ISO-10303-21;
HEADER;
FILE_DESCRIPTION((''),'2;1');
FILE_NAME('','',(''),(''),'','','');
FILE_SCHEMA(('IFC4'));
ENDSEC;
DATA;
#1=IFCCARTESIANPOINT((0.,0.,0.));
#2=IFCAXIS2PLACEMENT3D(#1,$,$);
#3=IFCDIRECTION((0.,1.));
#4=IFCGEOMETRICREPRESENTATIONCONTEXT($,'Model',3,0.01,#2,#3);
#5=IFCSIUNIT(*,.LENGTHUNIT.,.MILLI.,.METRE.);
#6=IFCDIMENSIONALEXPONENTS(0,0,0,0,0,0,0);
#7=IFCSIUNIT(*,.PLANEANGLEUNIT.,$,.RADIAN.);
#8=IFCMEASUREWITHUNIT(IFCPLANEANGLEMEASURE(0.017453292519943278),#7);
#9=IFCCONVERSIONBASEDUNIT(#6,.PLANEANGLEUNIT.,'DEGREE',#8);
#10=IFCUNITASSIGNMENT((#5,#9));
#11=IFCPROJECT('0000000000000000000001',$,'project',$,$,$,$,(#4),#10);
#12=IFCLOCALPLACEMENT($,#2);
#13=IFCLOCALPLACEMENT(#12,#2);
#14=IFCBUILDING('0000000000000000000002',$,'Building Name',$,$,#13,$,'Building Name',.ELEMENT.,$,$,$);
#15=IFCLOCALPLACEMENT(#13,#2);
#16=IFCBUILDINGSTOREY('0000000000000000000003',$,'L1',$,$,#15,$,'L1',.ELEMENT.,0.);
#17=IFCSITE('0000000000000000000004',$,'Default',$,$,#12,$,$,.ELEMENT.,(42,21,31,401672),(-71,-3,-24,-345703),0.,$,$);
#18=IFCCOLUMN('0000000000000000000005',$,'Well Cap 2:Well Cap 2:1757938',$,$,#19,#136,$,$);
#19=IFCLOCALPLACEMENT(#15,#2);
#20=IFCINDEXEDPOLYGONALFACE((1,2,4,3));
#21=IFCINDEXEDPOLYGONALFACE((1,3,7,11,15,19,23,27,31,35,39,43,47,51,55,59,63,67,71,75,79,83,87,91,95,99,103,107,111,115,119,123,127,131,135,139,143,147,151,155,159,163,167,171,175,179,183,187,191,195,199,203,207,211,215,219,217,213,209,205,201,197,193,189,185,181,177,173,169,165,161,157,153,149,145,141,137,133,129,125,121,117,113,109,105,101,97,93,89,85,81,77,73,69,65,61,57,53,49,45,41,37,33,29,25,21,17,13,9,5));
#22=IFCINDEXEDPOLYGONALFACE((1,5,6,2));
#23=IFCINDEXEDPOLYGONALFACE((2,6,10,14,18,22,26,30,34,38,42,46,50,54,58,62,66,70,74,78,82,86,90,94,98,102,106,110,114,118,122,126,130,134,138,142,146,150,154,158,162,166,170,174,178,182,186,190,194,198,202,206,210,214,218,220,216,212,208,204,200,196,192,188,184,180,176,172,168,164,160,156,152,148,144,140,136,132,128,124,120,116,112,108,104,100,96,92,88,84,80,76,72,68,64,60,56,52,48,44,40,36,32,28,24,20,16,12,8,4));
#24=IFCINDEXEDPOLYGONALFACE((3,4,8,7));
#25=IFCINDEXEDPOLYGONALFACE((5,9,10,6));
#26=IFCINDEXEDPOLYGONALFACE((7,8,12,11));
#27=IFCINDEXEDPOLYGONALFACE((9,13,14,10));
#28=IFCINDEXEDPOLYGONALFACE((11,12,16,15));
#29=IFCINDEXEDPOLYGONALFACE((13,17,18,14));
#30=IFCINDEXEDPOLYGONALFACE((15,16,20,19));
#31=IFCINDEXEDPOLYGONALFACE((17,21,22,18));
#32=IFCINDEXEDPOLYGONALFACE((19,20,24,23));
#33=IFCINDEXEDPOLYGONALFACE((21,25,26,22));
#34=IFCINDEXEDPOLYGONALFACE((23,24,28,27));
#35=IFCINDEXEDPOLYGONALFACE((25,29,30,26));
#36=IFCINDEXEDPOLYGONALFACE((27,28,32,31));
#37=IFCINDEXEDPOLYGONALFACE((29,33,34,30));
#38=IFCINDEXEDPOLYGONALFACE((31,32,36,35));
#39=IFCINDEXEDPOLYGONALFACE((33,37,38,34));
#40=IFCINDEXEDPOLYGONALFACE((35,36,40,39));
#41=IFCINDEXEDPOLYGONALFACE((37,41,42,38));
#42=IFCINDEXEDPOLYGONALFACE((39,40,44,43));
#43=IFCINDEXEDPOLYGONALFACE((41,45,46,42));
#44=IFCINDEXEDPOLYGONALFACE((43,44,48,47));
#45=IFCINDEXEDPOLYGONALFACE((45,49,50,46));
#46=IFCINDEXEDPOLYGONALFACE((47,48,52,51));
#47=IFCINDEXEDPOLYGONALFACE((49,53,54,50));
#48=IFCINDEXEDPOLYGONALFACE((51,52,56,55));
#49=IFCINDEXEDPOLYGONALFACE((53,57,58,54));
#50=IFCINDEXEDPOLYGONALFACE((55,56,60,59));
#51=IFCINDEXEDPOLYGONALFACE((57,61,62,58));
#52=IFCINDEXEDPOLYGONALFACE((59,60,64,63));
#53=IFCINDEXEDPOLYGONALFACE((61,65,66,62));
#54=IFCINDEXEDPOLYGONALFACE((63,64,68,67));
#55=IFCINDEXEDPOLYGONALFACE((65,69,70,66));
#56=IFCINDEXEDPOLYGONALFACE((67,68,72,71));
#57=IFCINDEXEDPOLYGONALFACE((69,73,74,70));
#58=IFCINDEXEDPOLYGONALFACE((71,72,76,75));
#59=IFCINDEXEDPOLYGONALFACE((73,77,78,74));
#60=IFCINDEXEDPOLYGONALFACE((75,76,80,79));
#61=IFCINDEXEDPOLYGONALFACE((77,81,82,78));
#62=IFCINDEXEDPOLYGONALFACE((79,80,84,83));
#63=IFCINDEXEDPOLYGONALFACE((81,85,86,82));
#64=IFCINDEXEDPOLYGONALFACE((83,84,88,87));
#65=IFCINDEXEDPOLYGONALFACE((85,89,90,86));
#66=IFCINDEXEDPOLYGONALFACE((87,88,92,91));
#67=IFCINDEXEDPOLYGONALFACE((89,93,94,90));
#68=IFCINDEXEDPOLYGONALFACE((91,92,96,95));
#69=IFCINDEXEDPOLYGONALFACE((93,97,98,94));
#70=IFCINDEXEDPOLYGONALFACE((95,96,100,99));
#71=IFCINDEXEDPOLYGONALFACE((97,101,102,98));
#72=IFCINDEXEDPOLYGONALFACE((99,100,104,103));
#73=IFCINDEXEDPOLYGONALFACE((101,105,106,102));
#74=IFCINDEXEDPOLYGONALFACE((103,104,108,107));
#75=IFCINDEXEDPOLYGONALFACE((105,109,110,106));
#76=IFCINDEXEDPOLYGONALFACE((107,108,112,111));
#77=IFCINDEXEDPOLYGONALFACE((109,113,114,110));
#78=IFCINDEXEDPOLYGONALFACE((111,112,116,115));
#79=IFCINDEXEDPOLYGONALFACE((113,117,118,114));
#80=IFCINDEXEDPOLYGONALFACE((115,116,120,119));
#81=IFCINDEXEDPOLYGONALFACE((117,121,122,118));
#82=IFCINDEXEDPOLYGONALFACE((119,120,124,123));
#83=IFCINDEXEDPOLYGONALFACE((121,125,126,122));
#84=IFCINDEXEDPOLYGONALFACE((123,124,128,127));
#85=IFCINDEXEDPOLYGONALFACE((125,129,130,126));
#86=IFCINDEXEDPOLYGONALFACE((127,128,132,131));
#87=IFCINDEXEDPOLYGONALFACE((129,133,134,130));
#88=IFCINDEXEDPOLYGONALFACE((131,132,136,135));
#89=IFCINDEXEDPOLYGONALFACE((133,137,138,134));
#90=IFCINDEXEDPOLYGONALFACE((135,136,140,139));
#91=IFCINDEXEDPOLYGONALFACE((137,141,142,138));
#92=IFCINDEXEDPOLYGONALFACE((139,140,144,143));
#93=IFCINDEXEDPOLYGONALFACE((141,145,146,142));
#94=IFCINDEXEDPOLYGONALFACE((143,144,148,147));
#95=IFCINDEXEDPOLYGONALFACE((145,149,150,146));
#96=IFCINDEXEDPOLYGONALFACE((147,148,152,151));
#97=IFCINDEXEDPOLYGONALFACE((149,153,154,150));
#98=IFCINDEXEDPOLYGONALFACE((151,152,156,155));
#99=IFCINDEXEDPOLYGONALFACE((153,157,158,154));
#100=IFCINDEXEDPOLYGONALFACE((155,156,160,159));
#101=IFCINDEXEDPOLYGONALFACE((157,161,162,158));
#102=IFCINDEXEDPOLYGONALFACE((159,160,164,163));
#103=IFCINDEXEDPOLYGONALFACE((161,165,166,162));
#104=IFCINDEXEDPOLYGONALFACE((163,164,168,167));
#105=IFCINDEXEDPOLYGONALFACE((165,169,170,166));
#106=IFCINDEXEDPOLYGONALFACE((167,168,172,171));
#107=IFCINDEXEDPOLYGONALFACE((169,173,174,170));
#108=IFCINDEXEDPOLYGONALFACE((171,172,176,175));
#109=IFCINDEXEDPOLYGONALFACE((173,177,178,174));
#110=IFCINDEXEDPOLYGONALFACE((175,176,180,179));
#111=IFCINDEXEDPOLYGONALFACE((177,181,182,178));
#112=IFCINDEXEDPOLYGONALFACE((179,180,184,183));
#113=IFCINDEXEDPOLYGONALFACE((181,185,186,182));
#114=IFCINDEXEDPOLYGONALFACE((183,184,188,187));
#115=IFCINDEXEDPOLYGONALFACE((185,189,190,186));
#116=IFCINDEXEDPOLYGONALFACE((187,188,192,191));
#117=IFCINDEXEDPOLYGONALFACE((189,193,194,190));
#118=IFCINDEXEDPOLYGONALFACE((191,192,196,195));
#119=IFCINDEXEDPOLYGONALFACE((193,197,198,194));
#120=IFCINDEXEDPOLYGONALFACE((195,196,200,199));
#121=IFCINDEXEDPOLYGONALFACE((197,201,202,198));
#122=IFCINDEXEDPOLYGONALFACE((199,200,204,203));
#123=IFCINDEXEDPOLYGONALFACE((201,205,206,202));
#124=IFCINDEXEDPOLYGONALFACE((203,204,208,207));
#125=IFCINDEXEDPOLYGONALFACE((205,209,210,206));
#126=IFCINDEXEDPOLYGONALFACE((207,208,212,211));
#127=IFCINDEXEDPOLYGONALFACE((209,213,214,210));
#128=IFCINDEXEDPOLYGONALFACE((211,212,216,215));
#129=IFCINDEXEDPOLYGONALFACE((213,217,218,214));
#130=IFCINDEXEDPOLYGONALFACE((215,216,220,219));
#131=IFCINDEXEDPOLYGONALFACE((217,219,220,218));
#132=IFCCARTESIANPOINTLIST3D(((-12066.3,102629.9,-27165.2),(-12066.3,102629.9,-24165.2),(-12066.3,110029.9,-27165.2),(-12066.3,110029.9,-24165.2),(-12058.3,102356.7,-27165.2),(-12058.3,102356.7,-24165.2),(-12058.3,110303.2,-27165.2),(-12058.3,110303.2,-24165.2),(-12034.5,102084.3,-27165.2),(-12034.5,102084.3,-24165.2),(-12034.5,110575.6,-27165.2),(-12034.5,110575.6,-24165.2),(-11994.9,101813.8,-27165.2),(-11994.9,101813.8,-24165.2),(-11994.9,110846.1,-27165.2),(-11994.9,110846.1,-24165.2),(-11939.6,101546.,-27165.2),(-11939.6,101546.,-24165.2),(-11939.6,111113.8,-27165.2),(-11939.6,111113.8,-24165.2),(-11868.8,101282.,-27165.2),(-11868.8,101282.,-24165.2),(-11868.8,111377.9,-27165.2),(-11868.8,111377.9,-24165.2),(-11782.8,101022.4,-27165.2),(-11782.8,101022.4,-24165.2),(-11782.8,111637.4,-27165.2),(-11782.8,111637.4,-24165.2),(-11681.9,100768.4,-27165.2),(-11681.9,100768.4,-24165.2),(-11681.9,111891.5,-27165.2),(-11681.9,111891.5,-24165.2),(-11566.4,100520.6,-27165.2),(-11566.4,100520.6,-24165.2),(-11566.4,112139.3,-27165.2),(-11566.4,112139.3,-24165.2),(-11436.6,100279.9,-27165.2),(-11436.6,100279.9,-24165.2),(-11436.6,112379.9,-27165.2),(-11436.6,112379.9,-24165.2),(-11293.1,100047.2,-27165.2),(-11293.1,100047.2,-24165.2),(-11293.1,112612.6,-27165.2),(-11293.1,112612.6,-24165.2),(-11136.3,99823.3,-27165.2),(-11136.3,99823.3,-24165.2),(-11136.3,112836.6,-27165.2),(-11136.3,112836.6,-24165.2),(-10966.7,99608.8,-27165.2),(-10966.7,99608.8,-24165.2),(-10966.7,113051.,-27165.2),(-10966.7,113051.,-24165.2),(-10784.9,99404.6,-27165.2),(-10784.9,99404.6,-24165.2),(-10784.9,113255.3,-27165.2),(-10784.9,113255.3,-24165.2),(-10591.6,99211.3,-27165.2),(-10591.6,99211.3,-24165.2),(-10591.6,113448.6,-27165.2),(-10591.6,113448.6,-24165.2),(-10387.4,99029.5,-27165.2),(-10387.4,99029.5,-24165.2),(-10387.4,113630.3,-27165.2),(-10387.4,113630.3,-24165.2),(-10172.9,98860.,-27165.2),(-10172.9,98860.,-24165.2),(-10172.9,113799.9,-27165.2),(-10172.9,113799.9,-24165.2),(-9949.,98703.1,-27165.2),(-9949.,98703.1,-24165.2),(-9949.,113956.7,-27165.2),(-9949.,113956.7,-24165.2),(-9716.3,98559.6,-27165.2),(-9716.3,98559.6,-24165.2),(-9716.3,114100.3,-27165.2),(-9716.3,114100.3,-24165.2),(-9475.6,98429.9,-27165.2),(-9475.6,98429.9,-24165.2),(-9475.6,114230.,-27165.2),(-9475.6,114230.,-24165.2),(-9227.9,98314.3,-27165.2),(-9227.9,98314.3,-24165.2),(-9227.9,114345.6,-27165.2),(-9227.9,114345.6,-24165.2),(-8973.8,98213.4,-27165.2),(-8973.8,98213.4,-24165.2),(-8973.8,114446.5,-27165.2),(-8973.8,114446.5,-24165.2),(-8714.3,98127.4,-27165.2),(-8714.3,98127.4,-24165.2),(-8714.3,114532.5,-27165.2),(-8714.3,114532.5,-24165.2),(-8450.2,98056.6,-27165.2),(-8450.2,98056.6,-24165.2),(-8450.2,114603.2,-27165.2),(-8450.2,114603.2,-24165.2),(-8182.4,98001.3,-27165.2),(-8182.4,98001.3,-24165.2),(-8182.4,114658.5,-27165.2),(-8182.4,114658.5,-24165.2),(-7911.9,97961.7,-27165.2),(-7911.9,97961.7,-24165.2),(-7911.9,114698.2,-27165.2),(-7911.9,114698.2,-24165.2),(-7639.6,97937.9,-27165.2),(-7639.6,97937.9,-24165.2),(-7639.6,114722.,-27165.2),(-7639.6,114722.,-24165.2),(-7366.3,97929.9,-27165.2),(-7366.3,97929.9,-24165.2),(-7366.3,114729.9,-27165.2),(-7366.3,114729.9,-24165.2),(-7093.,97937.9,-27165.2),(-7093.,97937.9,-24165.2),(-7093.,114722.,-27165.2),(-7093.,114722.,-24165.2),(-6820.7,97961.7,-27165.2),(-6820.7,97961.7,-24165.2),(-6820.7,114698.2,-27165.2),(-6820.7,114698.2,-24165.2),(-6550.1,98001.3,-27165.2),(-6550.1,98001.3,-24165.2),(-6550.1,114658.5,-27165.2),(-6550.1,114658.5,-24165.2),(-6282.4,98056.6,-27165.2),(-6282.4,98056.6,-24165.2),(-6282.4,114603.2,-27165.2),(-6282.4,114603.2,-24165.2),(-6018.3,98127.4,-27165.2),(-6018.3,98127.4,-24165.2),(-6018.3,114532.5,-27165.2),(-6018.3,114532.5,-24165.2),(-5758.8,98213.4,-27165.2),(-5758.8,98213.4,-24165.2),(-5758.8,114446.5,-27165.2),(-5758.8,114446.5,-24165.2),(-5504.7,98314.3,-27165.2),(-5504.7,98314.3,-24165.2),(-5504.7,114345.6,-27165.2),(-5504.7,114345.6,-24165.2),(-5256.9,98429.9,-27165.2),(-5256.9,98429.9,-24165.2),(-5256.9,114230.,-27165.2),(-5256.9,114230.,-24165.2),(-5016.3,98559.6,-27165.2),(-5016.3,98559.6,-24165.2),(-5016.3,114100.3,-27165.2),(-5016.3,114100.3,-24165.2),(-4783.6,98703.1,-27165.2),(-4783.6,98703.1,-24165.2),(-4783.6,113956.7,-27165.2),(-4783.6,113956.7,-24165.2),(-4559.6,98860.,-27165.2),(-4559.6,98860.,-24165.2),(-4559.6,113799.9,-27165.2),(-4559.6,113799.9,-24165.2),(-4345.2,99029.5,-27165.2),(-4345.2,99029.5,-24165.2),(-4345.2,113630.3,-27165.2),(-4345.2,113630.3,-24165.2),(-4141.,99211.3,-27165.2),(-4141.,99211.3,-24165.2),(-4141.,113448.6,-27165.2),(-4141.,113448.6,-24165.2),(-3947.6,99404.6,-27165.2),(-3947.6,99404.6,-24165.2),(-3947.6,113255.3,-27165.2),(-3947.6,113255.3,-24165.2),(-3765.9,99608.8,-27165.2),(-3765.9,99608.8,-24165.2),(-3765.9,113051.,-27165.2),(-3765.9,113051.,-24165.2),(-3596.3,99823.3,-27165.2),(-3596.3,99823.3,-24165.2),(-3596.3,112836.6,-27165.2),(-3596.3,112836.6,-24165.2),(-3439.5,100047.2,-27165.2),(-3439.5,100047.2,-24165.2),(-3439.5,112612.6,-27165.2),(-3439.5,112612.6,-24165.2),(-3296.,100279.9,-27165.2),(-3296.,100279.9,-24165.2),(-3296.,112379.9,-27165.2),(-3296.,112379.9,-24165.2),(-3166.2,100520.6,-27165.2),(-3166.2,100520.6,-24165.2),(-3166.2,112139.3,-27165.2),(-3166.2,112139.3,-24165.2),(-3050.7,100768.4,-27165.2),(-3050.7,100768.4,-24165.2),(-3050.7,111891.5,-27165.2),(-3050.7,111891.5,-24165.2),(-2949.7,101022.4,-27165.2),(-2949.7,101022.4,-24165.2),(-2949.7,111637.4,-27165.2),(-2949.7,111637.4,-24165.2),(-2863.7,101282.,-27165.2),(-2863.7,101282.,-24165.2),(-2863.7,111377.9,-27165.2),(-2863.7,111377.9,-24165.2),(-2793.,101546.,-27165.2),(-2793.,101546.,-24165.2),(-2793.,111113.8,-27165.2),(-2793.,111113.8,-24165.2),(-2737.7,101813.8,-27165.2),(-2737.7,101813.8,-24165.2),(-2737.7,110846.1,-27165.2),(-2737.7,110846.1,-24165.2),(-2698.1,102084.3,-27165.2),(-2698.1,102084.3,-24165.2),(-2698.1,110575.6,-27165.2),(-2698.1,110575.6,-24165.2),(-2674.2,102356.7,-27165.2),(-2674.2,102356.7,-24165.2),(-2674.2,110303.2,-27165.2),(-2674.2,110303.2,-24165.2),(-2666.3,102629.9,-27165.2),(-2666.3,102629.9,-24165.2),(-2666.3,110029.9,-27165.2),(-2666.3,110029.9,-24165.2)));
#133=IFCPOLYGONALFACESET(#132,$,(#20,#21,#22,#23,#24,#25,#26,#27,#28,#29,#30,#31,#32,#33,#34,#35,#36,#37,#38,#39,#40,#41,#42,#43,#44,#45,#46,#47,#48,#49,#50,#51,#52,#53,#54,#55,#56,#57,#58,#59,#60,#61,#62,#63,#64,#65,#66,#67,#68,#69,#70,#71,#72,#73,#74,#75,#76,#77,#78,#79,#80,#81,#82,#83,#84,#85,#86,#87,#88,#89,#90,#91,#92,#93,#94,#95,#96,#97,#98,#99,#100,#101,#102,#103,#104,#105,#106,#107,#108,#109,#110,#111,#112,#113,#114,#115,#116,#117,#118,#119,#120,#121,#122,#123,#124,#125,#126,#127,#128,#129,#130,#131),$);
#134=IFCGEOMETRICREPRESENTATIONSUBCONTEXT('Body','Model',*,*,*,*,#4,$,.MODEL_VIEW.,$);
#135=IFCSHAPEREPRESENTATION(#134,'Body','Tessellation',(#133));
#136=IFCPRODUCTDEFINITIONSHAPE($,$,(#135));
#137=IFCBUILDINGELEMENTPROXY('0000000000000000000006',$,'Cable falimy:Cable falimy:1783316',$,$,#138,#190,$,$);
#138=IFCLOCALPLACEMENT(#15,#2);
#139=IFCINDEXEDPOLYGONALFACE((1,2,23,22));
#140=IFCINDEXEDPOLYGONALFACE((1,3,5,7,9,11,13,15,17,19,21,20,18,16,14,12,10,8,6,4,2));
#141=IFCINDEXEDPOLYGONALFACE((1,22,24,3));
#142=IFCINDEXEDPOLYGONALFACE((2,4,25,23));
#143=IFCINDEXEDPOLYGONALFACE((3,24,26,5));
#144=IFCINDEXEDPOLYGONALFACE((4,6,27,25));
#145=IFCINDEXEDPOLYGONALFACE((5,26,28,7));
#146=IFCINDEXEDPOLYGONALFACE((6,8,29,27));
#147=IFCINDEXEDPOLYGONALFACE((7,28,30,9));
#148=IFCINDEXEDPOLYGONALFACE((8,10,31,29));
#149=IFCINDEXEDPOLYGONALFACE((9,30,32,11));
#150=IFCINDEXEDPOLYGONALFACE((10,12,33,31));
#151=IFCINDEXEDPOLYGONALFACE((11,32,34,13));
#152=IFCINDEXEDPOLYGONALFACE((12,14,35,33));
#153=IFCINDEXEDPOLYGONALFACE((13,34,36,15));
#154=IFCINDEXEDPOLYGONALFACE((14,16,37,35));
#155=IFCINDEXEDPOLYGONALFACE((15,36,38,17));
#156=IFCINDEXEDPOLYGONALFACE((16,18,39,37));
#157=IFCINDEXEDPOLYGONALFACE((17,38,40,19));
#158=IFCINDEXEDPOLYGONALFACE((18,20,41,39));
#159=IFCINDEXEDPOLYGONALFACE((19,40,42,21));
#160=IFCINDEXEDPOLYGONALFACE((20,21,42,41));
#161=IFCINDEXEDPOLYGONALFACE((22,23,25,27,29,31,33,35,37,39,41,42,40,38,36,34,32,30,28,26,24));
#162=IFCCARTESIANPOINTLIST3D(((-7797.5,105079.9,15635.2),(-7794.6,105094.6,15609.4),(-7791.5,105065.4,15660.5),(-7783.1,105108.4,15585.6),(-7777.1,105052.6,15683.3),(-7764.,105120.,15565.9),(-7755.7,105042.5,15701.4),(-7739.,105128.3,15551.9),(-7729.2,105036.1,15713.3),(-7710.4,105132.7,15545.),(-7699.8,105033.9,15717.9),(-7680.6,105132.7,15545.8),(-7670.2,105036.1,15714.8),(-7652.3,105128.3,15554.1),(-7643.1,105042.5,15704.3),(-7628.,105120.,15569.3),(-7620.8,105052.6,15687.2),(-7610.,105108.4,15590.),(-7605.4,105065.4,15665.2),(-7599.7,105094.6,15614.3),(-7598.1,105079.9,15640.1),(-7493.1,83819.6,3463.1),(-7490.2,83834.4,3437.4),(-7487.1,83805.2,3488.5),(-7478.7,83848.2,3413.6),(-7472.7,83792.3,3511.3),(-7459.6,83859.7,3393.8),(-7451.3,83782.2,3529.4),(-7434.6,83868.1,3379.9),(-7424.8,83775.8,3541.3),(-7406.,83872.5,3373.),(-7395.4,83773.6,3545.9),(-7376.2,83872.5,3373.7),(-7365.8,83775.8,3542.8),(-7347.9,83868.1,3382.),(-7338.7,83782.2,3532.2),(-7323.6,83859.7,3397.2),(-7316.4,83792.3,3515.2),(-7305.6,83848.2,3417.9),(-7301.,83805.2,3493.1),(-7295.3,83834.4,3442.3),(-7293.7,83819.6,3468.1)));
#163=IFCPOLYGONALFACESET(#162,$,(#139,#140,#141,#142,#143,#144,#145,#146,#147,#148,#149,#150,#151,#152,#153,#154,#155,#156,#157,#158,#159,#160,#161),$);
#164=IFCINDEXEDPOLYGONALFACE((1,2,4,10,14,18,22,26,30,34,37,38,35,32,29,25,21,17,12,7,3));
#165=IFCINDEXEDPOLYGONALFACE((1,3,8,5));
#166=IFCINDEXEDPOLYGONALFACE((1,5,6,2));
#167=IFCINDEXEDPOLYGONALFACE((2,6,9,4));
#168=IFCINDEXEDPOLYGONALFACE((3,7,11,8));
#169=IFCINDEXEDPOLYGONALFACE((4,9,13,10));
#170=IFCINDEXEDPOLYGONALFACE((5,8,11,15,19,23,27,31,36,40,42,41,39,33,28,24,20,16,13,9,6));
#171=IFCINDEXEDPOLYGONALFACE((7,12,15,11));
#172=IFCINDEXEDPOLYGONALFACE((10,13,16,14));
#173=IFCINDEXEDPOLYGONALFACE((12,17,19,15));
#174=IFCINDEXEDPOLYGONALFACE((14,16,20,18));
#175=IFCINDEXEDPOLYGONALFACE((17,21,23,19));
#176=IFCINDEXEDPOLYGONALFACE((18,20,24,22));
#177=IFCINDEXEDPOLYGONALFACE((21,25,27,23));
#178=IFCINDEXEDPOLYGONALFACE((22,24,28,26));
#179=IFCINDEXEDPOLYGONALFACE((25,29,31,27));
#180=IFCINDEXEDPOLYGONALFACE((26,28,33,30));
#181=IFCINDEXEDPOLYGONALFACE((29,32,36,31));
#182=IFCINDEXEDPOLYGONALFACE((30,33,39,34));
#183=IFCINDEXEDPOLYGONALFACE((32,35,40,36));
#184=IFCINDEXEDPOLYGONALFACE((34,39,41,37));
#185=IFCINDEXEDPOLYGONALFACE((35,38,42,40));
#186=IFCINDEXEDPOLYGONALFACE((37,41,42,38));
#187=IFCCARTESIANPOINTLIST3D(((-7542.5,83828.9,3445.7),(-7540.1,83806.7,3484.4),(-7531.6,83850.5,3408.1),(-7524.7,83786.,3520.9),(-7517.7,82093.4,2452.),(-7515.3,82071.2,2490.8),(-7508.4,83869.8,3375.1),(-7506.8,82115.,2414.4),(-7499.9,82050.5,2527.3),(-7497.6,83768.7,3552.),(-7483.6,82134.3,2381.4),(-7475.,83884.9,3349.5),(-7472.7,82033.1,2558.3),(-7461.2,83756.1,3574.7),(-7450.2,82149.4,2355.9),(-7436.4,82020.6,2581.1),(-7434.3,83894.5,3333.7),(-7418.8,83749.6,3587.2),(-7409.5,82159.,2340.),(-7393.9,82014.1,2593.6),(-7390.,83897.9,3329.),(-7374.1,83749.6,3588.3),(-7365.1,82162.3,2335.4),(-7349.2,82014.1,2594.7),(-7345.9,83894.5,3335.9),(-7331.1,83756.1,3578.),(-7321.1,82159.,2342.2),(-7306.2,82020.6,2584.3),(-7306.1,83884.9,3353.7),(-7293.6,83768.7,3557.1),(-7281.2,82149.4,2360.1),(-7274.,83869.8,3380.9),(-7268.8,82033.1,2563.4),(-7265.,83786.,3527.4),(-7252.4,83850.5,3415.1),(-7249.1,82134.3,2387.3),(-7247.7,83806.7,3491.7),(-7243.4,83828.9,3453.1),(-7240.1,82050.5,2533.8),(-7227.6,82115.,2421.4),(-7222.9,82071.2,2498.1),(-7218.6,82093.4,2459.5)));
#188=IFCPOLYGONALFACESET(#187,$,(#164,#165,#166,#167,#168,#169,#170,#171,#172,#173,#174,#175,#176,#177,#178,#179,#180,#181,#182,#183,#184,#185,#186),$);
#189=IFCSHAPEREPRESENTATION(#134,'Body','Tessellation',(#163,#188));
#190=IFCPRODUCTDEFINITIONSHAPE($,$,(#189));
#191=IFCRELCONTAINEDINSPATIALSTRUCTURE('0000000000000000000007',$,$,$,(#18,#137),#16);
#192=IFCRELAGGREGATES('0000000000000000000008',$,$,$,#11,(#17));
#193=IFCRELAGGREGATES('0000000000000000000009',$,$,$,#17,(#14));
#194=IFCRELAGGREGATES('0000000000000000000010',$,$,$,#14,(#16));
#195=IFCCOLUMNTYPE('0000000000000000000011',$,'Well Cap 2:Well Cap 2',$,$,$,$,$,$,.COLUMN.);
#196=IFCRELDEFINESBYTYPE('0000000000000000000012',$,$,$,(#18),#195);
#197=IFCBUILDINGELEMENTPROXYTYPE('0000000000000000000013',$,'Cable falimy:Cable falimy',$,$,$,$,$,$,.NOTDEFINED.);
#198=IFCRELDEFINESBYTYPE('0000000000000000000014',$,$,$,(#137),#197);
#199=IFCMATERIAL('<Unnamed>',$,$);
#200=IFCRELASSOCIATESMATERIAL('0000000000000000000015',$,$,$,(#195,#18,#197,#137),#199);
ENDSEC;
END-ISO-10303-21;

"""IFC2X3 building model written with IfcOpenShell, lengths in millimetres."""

from ifc_helpers import new_model, entity, si_unit, converted_unit, direction, frame, frame_2d, origin, place, context, subcontext, project, spatial, polyline, circle_curve, parameter, trimmed, segment, composite_curve, circle, outline, extrude, source, transform, mapped, material, type_object, type_shapes, element, save


model = new_model("IFC2X3")

# Units and contexts
model_context = context("Model", 3, precision=0.01, world=origin(), true_north=direction((0.0, 1.0)))
body_context = subcontext(model_context, "Body", "Model", "MODEL_VIEW")
ifc_project = project(units=[si_unit("LENGTHUNIT", "METRE", prefix="MILLI"), converted_unit("PLANEANGLEUNIT", "DEGREE", entity("IfcPlaneAngleMeasure", 0.017453292519943278), si_unit("PLANEANGLEUNIT", "RADIAN"), dimensions=[0, 0, 0, 0, 0, 0, 0])], contexts=[model_context])

# Site, building, storey
site_placement = place(None, origin())
site = spatial("IfcSite", under=ifc_project, at=site_placement, Name="Default", CompositionType="ELEMENT", RefLatitude=(42, 21, 31, 401672), RefLongitude=(-71, -3, -24, -345703), RefElevation=0.0)
building_placement = place(site_placement, origin())
building = spatial("IfcBuilding", under=site, at=building_placement, Name="Building Name", LongName="Building Name", CompositionType="ELEMENT")
storey_placement = place(building_placement, origin())
storey = spatial("IfcBuildingStorey", under=building, at=storey_placement, Name="L1", LongName="L1", CompositionType="ELEMENT", Elevation=0.0)

# Column
ifc_material = material(Name="<Unnamed>")
column_type_1 = type_object("IfcColumnType", Name="Well Cap 2:Well Cap 2", PredefinedType="COLUMN", material=ifc_material)
shared_shape_1 = source(origin(), body_context, "Body", "SweptSolid", [
    extrude(outline(composite_curve([segment(polyline([(-3700.0, -4700.0), (3700.0, -4700.0)]), True, "CONTINUOUS"), segment(trimmed(circle_curve(frame_2d((3700.0, 0.0), x_axis=(0.0, -1.0)), 4700.0), [parameter(0.0)], [parameter(180.0)], True, "PARAMETER"), True, "CONTINUOUS"), segment(polyline([(3700.0, 4700.0), (-3700.0, 4700.0)]), True, "CONTINUOUS"), segment(trimmed(circle_curve(frame_2d((-3700.0, 0.0), x_axis=(0.0, 1.0)), 4700.0), [parameter(0.0)], [parameter(180.0)], True, "PARAMETER"), True, "CONTINUOUS")], self_intersect=False)), frame((8064.3, 0.0, 0.0), z_axis=(0.0, 0.0, 1.0), x_axis=(0.0, -1.0, 0.0)), (0.0, 0.0, 1.0), 3000.0),
])
type_shapes(column_type_1, [shared_shape_1])
column_1_placement = place(storey_placement, frame((-15430.5, 106329.9, -27165.2)))
element("IfcColumn", 1, at=column_1_placement, inside=storey, type_object=column_type_1, material=ifc_material, Name="Well Cap 2:Well Cap 2:1757938", context=body_context, shape_type="MappedRepresentation", body=[
    mapped(shared_shape_1, transform((0.0, 0.0, 0.0), scale=1.0)),
])

# Building element proxy
building_element_proxy_type_1 = type_object("IfcBuildingElementProxyType", Name="Cable falimy:Cable falimy", PredefinedType="NOTDEFINED", material=ifc_material)
shared_shape_2 = source(origin(), body_context, "Body", "SweptSolid", [
    extrude(circle(Radius=100.0, at=frame_2d((0.0, 0.0), x_axis=(1.0, 0.0))), frame((0.0, 0.0, 0.0), z_axis=(0.867765, 0.0, 0.496974), x_axis=(-0.496974, 0.0, 0.867765)), (0.0, 0.0, 1.0), 24500.0),
    extrude(circle(Radius=150.0, at=frame_2d((0.0, 0.0), x_axis=(1.0, 0.0))), frame((-1735.5, 0.0, -993.9), z_axis=(0.867765, 0.0, 0.496974), x_axis=(0.496974, 0.0, -0.867765)), (0.0, 0.0, 1.0), 2000.0),
])
type_shapes(building_element_proxy_type_1, [shared_shape_2])
proxy_1_placement = place(storey_placement, frame((-7393.2, 83823.3, 3459.1), z_axis=(-0.025001, 0.0, 0.999687), x_axis=(0.0, 1.0, 0.0)))
element("IfcBuildingElementProxy", 2, at=proxy_1_placement, inside=storey, type_object=building_element_proxy_type_1, material=ifc_material, Name="Cable falimy:Cable falimy:1783316", context=body_context, shape_type="MappedRepresentation", body=[
    mapped(shared_shape_2, transform((0.0, 0.0, 0.0), scale=1.0)),
])

save(model, "model.ifc")
